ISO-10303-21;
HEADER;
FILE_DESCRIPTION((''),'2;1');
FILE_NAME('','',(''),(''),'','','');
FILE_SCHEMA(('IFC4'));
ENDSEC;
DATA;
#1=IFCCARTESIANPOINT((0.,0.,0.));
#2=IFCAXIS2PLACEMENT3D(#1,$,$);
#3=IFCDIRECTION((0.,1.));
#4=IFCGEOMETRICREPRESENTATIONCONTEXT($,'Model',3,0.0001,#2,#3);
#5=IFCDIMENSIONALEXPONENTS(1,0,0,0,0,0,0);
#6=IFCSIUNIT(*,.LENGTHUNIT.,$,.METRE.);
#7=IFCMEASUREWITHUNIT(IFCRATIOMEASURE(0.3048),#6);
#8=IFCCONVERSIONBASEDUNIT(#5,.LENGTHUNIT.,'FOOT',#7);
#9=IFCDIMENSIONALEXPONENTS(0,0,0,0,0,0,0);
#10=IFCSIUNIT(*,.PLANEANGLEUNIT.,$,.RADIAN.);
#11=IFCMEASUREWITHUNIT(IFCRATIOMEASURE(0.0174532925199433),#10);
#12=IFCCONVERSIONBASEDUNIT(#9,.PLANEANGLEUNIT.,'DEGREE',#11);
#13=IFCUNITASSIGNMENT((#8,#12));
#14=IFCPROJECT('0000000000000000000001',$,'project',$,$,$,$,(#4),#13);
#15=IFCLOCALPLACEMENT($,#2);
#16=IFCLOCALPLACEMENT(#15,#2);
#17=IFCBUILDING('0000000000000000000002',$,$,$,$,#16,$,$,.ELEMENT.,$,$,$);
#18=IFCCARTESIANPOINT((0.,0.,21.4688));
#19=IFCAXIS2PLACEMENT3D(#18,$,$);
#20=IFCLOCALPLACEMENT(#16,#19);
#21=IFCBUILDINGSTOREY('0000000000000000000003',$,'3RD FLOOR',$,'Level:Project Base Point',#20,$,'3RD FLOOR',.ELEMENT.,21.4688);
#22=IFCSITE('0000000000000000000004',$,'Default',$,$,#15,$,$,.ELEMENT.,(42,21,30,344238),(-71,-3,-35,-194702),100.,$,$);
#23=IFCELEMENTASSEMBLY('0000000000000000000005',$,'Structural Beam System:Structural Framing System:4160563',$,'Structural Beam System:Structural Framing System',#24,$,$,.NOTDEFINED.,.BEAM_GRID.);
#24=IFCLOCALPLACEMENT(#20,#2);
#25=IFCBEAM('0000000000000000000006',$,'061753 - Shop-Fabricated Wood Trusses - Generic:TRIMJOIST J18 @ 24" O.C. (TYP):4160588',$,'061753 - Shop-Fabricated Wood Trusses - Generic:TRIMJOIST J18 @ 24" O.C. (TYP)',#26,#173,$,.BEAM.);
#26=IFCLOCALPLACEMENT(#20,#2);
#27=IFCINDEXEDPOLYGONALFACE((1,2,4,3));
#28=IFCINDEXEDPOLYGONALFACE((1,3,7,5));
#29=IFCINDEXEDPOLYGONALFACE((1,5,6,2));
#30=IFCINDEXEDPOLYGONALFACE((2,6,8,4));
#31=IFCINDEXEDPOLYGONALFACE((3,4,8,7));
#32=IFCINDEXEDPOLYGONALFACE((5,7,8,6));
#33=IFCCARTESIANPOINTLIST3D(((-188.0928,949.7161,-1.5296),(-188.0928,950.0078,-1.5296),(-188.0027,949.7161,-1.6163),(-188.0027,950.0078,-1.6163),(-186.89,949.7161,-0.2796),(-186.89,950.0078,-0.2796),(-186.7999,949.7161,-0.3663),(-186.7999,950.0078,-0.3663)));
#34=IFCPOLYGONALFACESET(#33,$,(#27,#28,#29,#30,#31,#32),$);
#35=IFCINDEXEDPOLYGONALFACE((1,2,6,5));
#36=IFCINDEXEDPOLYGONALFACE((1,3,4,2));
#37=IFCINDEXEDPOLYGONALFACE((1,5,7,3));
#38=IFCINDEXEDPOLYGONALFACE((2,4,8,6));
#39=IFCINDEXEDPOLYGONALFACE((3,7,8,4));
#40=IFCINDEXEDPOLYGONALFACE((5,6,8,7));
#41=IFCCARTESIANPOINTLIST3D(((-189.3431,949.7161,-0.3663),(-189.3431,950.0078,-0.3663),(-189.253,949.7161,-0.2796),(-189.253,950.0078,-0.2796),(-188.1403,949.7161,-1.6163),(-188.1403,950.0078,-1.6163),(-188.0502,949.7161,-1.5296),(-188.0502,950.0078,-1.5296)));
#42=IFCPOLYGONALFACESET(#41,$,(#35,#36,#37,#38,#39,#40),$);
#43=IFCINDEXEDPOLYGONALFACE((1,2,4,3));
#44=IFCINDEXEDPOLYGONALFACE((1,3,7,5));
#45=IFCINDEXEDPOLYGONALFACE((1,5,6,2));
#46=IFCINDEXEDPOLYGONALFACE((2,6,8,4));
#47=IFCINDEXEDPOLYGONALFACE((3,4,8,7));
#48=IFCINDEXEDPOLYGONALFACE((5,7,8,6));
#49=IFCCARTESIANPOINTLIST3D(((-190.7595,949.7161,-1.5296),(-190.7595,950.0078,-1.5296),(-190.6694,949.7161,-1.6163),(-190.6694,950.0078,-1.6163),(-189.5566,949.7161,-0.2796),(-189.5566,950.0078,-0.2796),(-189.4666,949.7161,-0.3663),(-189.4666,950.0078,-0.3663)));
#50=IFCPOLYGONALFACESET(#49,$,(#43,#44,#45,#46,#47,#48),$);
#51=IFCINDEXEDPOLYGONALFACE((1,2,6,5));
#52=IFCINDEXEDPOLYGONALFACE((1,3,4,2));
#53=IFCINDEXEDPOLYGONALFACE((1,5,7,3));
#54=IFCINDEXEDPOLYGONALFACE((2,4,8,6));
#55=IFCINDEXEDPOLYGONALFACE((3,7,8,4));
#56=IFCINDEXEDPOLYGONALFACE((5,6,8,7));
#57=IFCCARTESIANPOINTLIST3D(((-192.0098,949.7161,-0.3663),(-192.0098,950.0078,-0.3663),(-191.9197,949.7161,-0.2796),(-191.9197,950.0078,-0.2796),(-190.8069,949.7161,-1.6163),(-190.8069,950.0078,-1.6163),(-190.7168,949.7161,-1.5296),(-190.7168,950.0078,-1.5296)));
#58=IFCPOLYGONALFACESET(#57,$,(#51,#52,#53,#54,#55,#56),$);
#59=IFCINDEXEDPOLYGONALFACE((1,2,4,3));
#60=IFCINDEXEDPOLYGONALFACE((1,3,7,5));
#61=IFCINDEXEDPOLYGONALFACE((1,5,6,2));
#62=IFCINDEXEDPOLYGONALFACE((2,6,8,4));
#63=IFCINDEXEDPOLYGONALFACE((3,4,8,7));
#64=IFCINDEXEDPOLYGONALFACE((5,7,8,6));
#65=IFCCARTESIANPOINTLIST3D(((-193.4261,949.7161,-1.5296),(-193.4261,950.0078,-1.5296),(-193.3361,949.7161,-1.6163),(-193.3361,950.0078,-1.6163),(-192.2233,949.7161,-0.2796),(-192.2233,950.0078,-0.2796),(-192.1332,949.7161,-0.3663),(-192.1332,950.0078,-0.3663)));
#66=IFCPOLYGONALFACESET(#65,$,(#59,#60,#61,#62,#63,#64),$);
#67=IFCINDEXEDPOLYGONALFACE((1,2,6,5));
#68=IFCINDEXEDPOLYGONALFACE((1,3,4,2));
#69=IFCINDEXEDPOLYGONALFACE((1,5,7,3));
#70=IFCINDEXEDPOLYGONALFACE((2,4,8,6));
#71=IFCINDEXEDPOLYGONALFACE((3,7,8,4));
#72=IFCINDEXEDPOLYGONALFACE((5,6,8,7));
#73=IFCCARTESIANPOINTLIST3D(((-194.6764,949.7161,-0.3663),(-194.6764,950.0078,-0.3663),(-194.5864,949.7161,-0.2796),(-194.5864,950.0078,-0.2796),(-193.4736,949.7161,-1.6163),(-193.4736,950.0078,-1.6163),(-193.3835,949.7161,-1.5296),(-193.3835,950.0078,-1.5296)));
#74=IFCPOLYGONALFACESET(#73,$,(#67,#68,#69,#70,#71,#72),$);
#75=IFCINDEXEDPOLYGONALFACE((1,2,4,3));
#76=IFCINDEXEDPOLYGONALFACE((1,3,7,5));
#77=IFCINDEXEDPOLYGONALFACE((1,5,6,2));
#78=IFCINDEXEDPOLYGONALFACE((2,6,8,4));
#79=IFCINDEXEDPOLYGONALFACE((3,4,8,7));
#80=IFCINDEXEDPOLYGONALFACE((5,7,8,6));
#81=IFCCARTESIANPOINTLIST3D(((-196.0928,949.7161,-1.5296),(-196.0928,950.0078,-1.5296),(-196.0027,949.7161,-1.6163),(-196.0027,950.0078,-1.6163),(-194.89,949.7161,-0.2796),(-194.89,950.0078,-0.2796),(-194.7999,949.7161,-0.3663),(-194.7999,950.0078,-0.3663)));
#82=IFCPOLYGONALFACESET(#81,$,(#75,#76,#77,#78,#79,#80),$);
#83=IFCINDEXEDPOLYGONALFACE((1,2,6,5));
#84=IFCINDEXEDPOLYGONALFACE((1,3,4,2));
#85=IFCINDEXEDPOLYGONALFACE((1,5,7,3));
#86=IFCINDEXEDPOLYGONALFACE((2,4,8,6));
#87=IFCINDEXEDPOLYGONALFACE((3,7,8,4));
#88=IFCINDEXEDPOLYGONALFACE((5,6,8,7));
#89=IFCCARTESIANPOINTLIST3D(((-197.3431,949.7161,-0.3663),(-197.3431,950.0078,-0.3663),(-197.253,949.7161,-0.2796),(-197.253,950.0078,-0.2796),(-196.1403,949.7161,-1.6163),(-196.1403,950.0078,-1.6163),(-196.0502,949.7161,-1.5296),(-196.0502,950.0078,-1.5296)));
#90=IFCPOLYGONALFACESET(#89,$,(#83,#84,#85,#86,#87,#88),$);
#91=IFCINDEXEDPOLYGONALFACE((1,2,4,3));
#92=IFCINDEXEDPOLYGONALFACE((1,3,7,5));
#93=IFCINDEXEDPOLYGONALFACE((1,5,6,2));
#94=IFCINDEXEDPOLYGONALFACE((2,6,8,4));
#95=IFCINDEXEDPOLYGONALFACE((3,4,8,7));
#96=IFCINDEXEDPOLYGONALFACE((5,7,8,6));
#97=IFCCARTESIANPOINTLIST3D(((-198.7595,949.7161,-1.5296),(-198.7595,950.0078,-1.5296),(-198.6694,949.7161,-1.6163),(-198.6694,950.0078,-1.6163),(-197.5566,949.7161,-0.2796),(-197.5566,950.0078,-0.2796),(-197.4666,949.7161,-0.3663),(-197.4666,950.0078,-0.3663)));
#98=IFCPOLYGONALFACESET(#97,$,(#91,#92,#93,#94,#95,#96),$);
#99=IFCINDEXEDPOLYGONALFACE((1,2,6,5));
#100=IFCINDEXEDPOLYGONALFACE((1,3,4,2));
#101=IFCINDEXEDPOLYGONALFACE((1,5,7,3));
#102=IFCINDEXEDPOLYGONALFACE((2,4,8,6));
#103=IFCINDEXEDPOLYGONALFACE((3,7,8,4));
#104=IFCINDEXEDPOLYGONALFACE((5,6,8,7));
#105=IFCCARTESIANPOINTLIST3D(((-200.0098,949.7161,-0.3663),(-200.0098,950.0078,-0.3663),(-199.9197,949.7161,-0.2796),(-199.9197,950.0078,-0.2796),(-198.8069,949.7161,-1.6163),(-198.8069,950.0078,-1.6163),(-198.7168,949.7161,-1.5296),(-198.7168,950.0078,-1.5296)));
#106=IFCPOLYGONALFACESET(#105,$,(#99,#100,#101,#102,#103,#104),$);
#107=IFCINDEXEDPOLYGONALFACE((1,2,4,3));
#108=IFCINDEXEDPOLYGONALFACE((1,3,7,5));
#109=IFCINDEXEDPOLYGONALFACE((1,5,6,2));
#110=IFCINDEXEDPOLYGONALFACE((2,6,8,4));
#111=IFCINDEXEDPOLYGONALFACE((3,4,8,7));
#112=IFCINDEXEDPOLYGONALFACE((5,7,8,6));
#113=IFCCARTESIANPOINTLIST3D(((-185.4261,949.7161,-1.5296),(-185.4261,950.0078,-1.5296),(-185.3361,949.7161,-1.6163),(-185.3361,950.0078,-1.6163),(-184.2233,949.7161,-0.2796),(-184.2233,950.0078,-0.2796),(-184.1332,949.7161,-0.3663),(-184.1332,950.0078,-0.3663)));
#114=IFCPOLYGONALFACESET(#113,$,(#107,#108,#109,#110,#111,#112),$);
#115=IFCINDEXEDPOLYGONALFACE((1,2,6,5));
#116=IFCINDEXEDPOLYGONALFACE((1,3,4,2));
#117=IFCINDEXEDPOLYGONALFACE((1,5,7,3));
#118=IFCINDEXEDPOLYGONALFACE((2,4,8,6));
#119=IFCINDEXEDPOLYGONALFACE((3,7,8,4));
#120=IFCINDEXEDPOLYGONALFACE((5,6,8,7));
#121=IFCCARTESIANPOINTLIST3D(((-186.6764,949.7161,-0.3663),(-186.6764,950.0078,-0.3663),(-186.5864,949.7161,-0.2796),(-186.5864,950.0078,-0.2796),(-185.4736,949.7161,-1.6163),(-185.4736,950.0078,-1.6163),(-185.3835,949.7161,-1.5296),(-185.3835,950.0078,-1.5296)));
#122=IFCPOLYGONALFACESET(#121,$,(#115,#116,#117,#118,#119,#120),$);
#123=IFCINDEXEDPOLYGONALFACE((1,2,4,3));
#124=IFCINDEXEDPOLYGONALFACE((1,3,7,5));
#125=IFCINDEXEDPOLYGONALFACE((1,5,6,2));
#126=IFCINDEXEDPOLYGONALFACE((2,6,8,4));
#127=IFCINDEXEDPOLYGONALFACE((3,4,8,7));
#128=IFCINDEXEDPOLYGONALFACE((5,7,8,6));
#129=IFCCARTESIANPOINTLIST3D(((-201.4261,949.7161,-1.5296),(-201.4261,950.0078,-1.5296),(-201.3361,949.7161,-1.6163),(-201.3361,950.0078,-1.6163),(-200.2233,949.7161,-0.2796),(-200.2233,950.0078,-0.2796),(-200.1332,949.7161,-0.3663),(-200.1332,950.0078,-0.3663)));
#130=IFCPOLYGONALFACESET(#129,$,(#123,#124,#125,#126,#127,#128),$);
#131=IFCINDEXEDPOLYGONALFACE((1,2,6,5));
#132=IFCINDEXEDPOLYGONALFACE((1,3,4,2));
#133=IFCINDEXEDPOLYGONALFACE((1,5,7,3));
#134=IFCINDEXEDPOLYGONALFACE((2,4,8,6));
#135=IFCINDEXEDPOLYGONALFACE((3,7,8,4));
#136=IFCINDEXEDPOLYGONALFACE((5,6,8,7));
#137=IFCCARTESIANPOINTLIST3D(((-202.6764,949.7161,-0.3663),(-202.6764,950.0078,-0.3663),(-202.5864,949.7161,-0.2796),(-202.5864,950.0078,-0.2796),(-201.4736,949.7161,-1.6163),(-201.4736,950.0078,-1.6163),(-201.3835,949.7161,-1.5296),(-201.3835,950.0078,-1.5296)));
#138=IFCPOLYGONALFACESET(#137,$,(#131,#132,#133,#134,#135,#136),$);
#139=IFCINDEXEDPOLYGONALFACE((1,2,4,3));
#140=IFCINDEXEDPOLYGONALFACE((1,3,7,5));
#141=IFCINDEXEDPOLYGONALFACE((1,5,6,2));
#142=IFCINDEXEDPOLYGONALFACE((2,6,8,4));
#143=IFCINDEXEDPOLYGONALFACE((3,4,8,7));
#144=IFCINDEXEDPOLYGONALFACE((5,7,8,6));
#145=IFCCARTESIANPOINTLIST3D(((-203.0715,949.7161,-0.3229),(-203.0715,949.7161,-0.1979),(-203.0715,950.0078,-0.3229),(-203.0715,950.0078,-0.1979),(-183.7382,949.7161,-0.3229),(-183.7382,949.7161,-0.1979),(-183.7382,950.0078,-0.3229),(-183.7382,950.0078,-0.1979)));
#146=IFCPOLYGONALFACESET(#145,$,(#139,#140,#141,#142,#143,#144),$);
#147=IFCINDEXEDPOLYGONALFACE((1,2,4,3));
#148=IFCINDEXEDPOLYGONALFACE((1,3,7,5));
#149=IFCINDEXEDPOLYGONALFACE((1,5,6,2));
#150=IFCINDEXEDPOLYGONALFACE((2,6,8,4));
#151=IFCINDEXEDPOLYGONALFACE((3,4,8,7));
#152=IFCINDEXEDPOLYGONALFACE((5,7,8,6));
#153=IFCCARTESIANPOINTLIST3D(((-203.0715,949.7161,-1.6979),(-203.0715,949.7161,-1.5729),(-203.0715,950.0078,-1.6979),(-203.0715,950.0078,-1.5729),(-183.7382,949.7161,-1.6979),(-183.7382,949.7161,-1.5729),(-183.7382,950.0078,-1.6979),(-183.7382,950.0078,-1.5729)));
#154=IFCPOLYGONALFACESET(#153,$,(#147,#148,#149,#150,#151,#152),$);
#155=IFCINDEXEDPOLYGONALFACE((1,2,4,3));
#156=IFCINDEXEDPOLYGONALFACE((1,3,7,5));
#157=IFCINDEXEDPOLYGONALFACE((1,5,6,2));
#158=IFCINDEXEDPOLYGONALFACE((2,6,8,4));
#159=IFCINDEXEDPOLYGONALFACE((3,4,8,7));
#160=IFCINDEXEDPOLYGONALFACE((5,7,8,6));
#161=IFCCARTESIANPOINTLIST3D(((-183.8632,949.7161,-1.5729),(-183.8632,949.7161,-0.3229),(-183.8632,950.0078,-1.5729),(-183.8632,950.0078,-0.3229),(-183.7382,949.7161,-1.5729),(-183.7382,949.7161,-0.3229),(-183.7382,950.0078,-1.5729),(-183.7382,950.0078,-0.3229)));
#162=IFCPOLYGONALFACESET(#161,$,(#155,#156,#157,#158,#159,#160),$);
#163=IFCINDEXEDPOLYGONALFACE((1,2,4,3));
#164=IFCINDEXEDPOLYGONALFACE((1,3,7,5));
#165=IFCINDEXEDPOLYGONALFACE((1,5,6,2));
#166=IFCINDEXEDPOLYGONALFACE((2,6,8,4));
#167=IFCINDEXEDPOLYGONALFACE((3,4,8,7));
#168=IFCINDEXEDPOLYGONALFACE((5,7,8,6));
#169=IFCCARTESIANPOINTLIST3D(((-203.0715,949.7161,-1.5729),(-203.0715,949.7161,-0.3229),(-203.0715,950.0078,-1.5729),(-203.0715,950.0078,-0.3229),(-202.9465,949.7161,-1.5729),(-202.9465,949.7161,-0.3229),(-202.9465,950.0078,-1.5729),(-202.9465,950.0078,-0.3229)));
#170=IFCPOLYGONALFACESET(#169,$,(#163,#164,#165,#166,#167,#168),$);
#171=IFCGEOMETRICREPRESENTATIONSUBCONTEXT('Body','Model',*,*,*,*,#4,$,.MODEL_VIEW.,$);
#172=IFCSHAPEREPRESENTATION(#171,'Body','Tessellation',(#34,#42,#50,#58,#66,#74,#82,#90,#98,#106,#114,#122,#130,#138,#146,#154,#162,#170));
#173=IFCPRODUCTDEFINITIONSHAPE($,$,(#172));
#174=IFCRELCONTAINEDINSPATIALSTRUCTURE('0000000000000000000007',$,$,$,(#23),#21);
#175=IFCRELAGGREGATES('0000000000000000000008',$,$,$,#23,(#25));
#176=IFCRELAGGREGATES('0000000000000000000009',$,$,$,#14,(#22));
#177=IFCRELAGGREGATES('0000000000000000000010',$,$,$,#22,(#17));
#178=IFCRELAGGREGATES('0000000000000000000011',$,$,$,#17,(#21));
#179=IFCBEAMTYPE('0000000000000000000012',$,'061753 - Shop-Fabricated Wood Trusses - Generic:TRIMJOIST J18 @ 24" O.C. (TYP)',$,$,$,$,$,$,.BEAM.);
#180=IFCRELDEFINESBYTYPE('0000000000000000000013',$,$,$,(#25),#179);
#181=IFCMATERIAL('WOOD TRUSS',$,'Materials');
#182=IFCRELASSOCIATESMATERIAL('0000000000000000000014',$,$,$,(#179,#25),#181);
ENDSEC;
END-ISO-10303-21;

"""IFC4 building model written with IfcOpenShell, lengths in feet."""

from ifc_helpers import new_model, entity, si_unit, converted_unit, direction, frame, frame_2d, origin, origin_2d_with_axis, place, context, subcontext, project, spatial, rectangle, extrude, source, transform, mapped, material, material_profile, profile_set, profile_usage, type_object, type_shapes, element, aggregate, save


model = new_model("IFC4")

# Units and contexts
model_context = context("Model", 3, precision=0.0001, world=origin(), true_north=direction((0.0, 1.0)))
body_context = subcontext(model_context, "Body", "Model", "MODEL_VIEW")
ifc_project = project(units=[converted_unit("LENGTHUNIT", "FOOT", entity("IfcRatioMeasure", 0.3048), si_unit("LENGTHUNIT", "METRE"), dimensions=[1, 0, 0, 0, 0, 0, 0]), converted_unit("PLANEANGLEUNIT", "DEGREE", entity("IfcRatioMeasure", 0.0174532925199433), si_unit("PLANEANGLEUNIT", "RADIAN"), dimensions=[0, 0, 0, 0, 0, 0, 0])], contexts=[model_context])

# Site, building, storey
site_placement = place(None, origin())
site = spatial("IfcSite", under=ifc_project, at=site_placement, Name="Default", CompositionType="ELEMENT", RefLatitude=(42, 21, 30, 344238), RefLongitude=(-71, -3, -35, -194702), RefElevation=100.0)
building_placement = place(site_placement, origin())
building = spatial("IfcBuilding", under=site, at=building_placement, CompositionType="ELEMENT")
storey_placement = place(building_placement, frame((0.0, 0.0, 21.4688)))
storey = spatial("IfcBuildingStorey", under=building, at=storey_placement, Name="3RD FLOOR", ObjectType="Level:Project Base Point", LongName="3RD FLOOR", CompositionType="ELEMENT", Elevation=21.4688)

# Element assembly, beam
ifc_material = material(Name="WOOD TRUSS", Category="Materials")
ifc_material_profile_1 = material_profile(ifc_material, rectangle(XDim=1.7347, YDim=0.125, at=frame_2d((0.0, 0.0), x_axis=(1.0, 0.0))), Name="TRIMJOIST J18 @ 24\" O.C. (TYP)")
ifc_material_profile_2 = material_profile(ifc_material, rectangle(XDim=1.7347, YDim=0.125, at=frame_2d((0.0, 0.0), x_axis=(1.0, 0.0))), Name="TRIMJOIST J18 @ 24\" O.C. (TYP)")
ifc_material_profile_3 = material_profile(ifc_material, rectangle(XDim=1.7347, YDim=0.125, at=frame_2d((0.0, 0.0), x_axis=(1.0, 0.0))), Name="TRIMJOIST J18 @ 24\" O.C. (TYP)")
ifc_material_profile_4 = material_profile(ifc_material, rectangle(XDim=1.7347, YDim=0.125, at=frame_2d((0.0, 0.0), x_axis=(1.0, 0.0))), Name="TRIMJOIST J18 @ 24\" O.C. (TYP)")
ifc_material_profile_5 = material_profile(ifc_material, rectangle(XDim=1.7347, YDim=0.125, at=frame_2d((0.0, 0.0), x_axis=(1.0, 0.0))), Name="TRIMJOIST J18 @ 24\" O.C. (TYP)")
ifc_material_profile_6 = material_profile(ifc_material, rectangle(XDim=1.7347, YDim=0.125, at=frame_2d((0.0, 0.0), x_axis=(1.0, 0.0))), Name="TRIMJOIST J18 @ 24\" O.C. (TYP)")
ifc_material_profile_7 = material_profile(ifc_material, rectangle(XDim=1.7347, YDim=0.125, at=frame_2d((0.0, 0.0), x_axis=(1.0, 0.0))), Name="TRIMJOIST J18 @ 24\" O.C. (TYP)")
ifc_material_profile_8 = material_profile(ifc_material, rectangle(XDim=1.7347, YDim=0.125, at=frame_2d((0.0, 0.0), x_axis=(1.0, 0.0))), Name="TRIMJOIST J18 @ 24\" O.C. (TYP)")
ifc_material_profile_9 = material_profile(ifc_material, rectangle(XDim=1.7347, YDim=0.125, at=frame_2d((0.0, 0.0), x_axis=(1.0, 0.0))), Name="TRIMJOIST J18 @ 24\" O.C. (TYP)")
ifc_material_profile_10 = material_profile(ifc_material, rectangle(XDim=1.7347, YDim=0.125, at=origin_2d_with_axis()), Name="TRIMJOIST J18 @ 24\" O.C. (TYP)")
ifc_material_profile_11 = material_profile(ifc_material, rectangle(XDim=0.125, YDim=0.2917, at=origin_2d_with_axis()), Name="TRIMJOIST J18 @ 24\" O.C. (TYP)")
ifc_material_profile_12 = material_profile(ifc_material, rectangle(XDim=0.125, YDim=0.2917, at=origin_2d_with_axis()), Name="TRIMJOIST J18 @ 24\" O.C. (TYP)")
ifc_material_profile_13 = material_profile(ifc_material, rectangle(XDim=1.25, YDim=0.2917, at=origin_2d_with_axis()), Name="TRIMJOIST J18 @ 24\" O.C. (TYP)")
ifc_material_profile_14 = material_profile(ifc_material, rectangle(XDim=1.25, YDim=0.2917, at=origin_2d_with_axis()), Name="TRIMJOIST J18 @ 24\" O.C. (TYP)")
ifc_profile_set = profile_set([ifc_material_profile_1, ifc_material_profile_2, ifc_material_profile_3, ifc_material_profile_4, ifc_material_profile_5, ifc_material_profile_6, ifc_material_profile_7, ifc_material_profile_8, ifc_material_profile_9, ifc_material_profile_10, ifc_material_profile_11, ifc_material_profile_12, ifc_material_profile_13, ifc_material_profile_14], Name="TRIMJOIST J18 @ 24\" O.C. (TYP)")
beam_type_1 = type_object("IfcBeamType", Name="061753 - Shop-Fabricated Wood Trusses - Generic:TRIMJOIST J18 @ 24\" O.C. (TYP)", PredefinedType="BEAM", material=ifc_profile_set)
shared_shape_1 = source(origin(), body_context, "Body", "SweptSolid", [
    extrude(rectangle(XDim=1.7347, YDim=0.125, at=frame_2d((0.0, 0.0), x_axis=(1.0, 0.0))), frame((5.9585, -0.1458, 0.0), z_axis=(0.0, 1.0, 0.0), x_axis=(0.693383, 0.0, 0.720569)), (0.0, 0.0, 1.0), 0.2917),
    extrude(rectangle(XDim=1.7347, YDim=0.125, at=origin_2d_with_axis()), frame((4.7082, -0.1458, 0.0), z_axis=(0.0, 1.0, 0.0), x_axis=(0.693383, 0.0, -0.720569)), (0.0, 0.0, 1.0), 0.2917),
    extrude(rectangle(XDim=1.7347, YDim=0.125, at=frame_2d((0.0, 0.0), x_axis=(1.0, 0.0))), frame((3.2918, -0.1458, 0.0), z_axis=(0.0, 1.0, 0.0), x_axis=(0.693383, 0.0, 0.720569)), (0.0, 0.0, 1.0), 0.2917),
    extrude(rectangle(XDim=1.7347, YDim=0.125, at=frame_2d((0.0, 0.0), x_axis=(1.0, 0.0))), frame((2.0415, -0.1458, 0.0), z_axis=(0.0, 1.0, 0.0), x_axis=(0.693383, 0.0, -0.720569)), (0.0, 0.0, 1.0), 0.2917),
    extrude(rectangle(XDim=1.7347, YDim=0.125, at=frame_2d((0.0, 0.0), x_axis=(1.0, 0.0))), frame((0.6251, -0.1458, 0.0), z_axis=(0.0, 1.0, 0.0), x_axis=(0.693383, 0.0, 0.720569)), (0.0, 0.0, 1.0), 0.2917),
    extrude(rectangle(XDim=1.7347, YDim=0.125, at=frame_2d((0.0, 0.0), x_axis=(1.0, 0.0))), frame((-0.6251, -0.1458, 0.0), z_axis=(0.0, 1.0, 0.0), x_axis=(0.693383, 0.0, -0.720569)), (0.0, 0.0, 1.0), 0.2917),
    extrude(rectangle(XDim=1.7347, YDim=0.125, at=frame_2d((0.0, 0.0), x_axis=(1.0, 0.0))), frame((-2.0415, -0.1458, 0.0), z_axis=(0.0, 1.0, 0.0), x_axis=(0.693383, 0.0, 0.720569)), (0.0, 0.0, 1.0), 0.2917),
    extrude(rectangle(XDim=1.7347, YDim=0.125, at=origin_2d_with_axis()), frame((-3.2918, -0.1458, 0.0), z_axis=(0.0, 1.0, 0.0), x_axis=(0.693383, 0.0, -0.720569)), (0.0, 0.0, 1.0), 0.2917),
    extrude(rectangle(XDim=1.7347, YDim=0.125, at=frame_2d((0.0, 0.0), x_axis=(1.0, 0.0))), frame((-4.7082, -0.1458, 0.0), z_axis=(0.0, 1.0, 0.0), x_axis=(0.693383, 0.0, 0.720569)), (0.0, 0.0, 1.0), 0.2917),
    extrude(rectangle(XDim=1.7347, YDim=0.125, at=frame_2d((0.0, 0.0), x_axis=(1.0, 0.0))), frame((-5.9585, -0.1458, 0.0), z_axis=(0.0, 1.0, 0.0), x_axis=(0.693383, 0.0, -0.720569)), (0.0, 0.0, 1.0), 0.2917),
    extrude(rectangle(XDim=1.7347, YDim=0.125, at=frame_2d((0.0, 0.0), x_axis=(1.0, 0.0))), frame((8.6251, -0.1458, 0.0), z_axis=(0.0, 1.0, 0.0), x_axis=(0.693383, 0.0, 0.720569)), (0.0, 0.0, 1.0), 0.2917),
    extrude(rectangle(XDim=1.7347, YDim=0.125, at=origin_2d_with_axis()), frame((7.3749, -0.1458, 0.0), z_axis=(0.0, 1.0, 0.0), x_axis=(0.693383, 0.0, -0.720569)), (0.0, 0.0, 1.0), 0.2917),
    extrude(rectangle(XDim=1.7347, YDim=0.125, at=frame_2d((0.0, 0.0), x_axis=(1.0, 0.0))), frame((-7.3749, -0.1458, 0.0), z_axis=(0.0, 1.0, 0.0), x_axis=(0.693383, 0.0, 0.720569)), (0.0, 0.0, 1.0), 0.2917),
    extrude(rectangle(XDim=1.7347, YDim=0.125, at=origin_2d_with_axis()), frame((-8.6251, -0.1458, 0.0), z_axis=(0.0, 1.0, 0.0), x_axis=(0.693383, 0.0, -0.720569)), (0.0, 0.0, 1.0), 0.2917),
    extrude(rectangle(XDim=0.125, YDim=0.2917, at=origin_2d_with_axis()), frame((-9.6667, 0.0, 0.6875), z_axis=(1.0, 0.0, 0.0), x_axis=(0.0, 0.0, -1.0)), (0.0, 0.0, 1.0), 19.3333),
    extrude(rectangle(XDim=0.125, YDim=0.2917, at=origin_2d_with_axis()), frame((-9.6667, 0.0, -0.6875), z_axis=(1.0, 0.0, 0.0), x_axis=(0.0, 0.0, -1.0)), (0.0, 0.0, 1.0), 19.3333),
    extrude(rectangle(XDim=1.25, YDim=0.2917, at=origin_2d_with_axis()), frame((9.5417, 0.0, 0.0), z_axis=(1.0, 0.0, 0.0), x_axis=(0.0, 0.0, -1.0)), (0.0, 0.0, 1.0), 0.125),
    extrude(rectangle(XDim=1.25, YDim=0.2917, at=origin_2d_with_axis()), frame((-9.6667, 0.0, 0.0), z_axis=(1.0, 0.0, 0.0), x_axis=(0.0, 0.0, -1.0)), (0.0, 0.0, 1.0), 0.125),
])
type_shapes(beam_type_1, [shared_shape_1])
assembly_1_placement = place(storey_placement, origin())
assembly_1 = element("IfcElementAssembly", 1, at=assembly_1_placement, inside=storey, Name="Structural Beam System:Structural Framing System:4160563", ObjectType="Structural Beam System:Structural Framing System", AssemblyPlace="NOTDEFINED", PredefinedType="BEAM_GRID")
ifc_profile_usage_1 = profile_usage(ifc_profile_set, cardinal=8)
beam_1_placement = place(assembly_1_placement, frame((-193.4048, 949.8619, -0.9479)))
beam_1 = element("IfcBeam", 2, at=beam_1_placement, type_object=beam_type_1, material=ifc_profile_usage_1, Name="061753 - Shop-Fabricated Wood Trusses - Generic:TRIMJOIST J18 @ 24\" O.C. (TYP):4160588", ObjectType="061753 - Shop-Fabricated Wood Trusses - Generic:TRIMJOIST J18 @ 24\" O.C. (TYP)", PredefinedType="BEAM", context=body_context, shape_type="MappedRepresentation", body=[
    mapped(shared_shape_1, transform((0.0, 0.0, 0.0), scale=1.0)),
])
aggregate(assembly_1, [beam_1])

save(model, "model.ifc")
